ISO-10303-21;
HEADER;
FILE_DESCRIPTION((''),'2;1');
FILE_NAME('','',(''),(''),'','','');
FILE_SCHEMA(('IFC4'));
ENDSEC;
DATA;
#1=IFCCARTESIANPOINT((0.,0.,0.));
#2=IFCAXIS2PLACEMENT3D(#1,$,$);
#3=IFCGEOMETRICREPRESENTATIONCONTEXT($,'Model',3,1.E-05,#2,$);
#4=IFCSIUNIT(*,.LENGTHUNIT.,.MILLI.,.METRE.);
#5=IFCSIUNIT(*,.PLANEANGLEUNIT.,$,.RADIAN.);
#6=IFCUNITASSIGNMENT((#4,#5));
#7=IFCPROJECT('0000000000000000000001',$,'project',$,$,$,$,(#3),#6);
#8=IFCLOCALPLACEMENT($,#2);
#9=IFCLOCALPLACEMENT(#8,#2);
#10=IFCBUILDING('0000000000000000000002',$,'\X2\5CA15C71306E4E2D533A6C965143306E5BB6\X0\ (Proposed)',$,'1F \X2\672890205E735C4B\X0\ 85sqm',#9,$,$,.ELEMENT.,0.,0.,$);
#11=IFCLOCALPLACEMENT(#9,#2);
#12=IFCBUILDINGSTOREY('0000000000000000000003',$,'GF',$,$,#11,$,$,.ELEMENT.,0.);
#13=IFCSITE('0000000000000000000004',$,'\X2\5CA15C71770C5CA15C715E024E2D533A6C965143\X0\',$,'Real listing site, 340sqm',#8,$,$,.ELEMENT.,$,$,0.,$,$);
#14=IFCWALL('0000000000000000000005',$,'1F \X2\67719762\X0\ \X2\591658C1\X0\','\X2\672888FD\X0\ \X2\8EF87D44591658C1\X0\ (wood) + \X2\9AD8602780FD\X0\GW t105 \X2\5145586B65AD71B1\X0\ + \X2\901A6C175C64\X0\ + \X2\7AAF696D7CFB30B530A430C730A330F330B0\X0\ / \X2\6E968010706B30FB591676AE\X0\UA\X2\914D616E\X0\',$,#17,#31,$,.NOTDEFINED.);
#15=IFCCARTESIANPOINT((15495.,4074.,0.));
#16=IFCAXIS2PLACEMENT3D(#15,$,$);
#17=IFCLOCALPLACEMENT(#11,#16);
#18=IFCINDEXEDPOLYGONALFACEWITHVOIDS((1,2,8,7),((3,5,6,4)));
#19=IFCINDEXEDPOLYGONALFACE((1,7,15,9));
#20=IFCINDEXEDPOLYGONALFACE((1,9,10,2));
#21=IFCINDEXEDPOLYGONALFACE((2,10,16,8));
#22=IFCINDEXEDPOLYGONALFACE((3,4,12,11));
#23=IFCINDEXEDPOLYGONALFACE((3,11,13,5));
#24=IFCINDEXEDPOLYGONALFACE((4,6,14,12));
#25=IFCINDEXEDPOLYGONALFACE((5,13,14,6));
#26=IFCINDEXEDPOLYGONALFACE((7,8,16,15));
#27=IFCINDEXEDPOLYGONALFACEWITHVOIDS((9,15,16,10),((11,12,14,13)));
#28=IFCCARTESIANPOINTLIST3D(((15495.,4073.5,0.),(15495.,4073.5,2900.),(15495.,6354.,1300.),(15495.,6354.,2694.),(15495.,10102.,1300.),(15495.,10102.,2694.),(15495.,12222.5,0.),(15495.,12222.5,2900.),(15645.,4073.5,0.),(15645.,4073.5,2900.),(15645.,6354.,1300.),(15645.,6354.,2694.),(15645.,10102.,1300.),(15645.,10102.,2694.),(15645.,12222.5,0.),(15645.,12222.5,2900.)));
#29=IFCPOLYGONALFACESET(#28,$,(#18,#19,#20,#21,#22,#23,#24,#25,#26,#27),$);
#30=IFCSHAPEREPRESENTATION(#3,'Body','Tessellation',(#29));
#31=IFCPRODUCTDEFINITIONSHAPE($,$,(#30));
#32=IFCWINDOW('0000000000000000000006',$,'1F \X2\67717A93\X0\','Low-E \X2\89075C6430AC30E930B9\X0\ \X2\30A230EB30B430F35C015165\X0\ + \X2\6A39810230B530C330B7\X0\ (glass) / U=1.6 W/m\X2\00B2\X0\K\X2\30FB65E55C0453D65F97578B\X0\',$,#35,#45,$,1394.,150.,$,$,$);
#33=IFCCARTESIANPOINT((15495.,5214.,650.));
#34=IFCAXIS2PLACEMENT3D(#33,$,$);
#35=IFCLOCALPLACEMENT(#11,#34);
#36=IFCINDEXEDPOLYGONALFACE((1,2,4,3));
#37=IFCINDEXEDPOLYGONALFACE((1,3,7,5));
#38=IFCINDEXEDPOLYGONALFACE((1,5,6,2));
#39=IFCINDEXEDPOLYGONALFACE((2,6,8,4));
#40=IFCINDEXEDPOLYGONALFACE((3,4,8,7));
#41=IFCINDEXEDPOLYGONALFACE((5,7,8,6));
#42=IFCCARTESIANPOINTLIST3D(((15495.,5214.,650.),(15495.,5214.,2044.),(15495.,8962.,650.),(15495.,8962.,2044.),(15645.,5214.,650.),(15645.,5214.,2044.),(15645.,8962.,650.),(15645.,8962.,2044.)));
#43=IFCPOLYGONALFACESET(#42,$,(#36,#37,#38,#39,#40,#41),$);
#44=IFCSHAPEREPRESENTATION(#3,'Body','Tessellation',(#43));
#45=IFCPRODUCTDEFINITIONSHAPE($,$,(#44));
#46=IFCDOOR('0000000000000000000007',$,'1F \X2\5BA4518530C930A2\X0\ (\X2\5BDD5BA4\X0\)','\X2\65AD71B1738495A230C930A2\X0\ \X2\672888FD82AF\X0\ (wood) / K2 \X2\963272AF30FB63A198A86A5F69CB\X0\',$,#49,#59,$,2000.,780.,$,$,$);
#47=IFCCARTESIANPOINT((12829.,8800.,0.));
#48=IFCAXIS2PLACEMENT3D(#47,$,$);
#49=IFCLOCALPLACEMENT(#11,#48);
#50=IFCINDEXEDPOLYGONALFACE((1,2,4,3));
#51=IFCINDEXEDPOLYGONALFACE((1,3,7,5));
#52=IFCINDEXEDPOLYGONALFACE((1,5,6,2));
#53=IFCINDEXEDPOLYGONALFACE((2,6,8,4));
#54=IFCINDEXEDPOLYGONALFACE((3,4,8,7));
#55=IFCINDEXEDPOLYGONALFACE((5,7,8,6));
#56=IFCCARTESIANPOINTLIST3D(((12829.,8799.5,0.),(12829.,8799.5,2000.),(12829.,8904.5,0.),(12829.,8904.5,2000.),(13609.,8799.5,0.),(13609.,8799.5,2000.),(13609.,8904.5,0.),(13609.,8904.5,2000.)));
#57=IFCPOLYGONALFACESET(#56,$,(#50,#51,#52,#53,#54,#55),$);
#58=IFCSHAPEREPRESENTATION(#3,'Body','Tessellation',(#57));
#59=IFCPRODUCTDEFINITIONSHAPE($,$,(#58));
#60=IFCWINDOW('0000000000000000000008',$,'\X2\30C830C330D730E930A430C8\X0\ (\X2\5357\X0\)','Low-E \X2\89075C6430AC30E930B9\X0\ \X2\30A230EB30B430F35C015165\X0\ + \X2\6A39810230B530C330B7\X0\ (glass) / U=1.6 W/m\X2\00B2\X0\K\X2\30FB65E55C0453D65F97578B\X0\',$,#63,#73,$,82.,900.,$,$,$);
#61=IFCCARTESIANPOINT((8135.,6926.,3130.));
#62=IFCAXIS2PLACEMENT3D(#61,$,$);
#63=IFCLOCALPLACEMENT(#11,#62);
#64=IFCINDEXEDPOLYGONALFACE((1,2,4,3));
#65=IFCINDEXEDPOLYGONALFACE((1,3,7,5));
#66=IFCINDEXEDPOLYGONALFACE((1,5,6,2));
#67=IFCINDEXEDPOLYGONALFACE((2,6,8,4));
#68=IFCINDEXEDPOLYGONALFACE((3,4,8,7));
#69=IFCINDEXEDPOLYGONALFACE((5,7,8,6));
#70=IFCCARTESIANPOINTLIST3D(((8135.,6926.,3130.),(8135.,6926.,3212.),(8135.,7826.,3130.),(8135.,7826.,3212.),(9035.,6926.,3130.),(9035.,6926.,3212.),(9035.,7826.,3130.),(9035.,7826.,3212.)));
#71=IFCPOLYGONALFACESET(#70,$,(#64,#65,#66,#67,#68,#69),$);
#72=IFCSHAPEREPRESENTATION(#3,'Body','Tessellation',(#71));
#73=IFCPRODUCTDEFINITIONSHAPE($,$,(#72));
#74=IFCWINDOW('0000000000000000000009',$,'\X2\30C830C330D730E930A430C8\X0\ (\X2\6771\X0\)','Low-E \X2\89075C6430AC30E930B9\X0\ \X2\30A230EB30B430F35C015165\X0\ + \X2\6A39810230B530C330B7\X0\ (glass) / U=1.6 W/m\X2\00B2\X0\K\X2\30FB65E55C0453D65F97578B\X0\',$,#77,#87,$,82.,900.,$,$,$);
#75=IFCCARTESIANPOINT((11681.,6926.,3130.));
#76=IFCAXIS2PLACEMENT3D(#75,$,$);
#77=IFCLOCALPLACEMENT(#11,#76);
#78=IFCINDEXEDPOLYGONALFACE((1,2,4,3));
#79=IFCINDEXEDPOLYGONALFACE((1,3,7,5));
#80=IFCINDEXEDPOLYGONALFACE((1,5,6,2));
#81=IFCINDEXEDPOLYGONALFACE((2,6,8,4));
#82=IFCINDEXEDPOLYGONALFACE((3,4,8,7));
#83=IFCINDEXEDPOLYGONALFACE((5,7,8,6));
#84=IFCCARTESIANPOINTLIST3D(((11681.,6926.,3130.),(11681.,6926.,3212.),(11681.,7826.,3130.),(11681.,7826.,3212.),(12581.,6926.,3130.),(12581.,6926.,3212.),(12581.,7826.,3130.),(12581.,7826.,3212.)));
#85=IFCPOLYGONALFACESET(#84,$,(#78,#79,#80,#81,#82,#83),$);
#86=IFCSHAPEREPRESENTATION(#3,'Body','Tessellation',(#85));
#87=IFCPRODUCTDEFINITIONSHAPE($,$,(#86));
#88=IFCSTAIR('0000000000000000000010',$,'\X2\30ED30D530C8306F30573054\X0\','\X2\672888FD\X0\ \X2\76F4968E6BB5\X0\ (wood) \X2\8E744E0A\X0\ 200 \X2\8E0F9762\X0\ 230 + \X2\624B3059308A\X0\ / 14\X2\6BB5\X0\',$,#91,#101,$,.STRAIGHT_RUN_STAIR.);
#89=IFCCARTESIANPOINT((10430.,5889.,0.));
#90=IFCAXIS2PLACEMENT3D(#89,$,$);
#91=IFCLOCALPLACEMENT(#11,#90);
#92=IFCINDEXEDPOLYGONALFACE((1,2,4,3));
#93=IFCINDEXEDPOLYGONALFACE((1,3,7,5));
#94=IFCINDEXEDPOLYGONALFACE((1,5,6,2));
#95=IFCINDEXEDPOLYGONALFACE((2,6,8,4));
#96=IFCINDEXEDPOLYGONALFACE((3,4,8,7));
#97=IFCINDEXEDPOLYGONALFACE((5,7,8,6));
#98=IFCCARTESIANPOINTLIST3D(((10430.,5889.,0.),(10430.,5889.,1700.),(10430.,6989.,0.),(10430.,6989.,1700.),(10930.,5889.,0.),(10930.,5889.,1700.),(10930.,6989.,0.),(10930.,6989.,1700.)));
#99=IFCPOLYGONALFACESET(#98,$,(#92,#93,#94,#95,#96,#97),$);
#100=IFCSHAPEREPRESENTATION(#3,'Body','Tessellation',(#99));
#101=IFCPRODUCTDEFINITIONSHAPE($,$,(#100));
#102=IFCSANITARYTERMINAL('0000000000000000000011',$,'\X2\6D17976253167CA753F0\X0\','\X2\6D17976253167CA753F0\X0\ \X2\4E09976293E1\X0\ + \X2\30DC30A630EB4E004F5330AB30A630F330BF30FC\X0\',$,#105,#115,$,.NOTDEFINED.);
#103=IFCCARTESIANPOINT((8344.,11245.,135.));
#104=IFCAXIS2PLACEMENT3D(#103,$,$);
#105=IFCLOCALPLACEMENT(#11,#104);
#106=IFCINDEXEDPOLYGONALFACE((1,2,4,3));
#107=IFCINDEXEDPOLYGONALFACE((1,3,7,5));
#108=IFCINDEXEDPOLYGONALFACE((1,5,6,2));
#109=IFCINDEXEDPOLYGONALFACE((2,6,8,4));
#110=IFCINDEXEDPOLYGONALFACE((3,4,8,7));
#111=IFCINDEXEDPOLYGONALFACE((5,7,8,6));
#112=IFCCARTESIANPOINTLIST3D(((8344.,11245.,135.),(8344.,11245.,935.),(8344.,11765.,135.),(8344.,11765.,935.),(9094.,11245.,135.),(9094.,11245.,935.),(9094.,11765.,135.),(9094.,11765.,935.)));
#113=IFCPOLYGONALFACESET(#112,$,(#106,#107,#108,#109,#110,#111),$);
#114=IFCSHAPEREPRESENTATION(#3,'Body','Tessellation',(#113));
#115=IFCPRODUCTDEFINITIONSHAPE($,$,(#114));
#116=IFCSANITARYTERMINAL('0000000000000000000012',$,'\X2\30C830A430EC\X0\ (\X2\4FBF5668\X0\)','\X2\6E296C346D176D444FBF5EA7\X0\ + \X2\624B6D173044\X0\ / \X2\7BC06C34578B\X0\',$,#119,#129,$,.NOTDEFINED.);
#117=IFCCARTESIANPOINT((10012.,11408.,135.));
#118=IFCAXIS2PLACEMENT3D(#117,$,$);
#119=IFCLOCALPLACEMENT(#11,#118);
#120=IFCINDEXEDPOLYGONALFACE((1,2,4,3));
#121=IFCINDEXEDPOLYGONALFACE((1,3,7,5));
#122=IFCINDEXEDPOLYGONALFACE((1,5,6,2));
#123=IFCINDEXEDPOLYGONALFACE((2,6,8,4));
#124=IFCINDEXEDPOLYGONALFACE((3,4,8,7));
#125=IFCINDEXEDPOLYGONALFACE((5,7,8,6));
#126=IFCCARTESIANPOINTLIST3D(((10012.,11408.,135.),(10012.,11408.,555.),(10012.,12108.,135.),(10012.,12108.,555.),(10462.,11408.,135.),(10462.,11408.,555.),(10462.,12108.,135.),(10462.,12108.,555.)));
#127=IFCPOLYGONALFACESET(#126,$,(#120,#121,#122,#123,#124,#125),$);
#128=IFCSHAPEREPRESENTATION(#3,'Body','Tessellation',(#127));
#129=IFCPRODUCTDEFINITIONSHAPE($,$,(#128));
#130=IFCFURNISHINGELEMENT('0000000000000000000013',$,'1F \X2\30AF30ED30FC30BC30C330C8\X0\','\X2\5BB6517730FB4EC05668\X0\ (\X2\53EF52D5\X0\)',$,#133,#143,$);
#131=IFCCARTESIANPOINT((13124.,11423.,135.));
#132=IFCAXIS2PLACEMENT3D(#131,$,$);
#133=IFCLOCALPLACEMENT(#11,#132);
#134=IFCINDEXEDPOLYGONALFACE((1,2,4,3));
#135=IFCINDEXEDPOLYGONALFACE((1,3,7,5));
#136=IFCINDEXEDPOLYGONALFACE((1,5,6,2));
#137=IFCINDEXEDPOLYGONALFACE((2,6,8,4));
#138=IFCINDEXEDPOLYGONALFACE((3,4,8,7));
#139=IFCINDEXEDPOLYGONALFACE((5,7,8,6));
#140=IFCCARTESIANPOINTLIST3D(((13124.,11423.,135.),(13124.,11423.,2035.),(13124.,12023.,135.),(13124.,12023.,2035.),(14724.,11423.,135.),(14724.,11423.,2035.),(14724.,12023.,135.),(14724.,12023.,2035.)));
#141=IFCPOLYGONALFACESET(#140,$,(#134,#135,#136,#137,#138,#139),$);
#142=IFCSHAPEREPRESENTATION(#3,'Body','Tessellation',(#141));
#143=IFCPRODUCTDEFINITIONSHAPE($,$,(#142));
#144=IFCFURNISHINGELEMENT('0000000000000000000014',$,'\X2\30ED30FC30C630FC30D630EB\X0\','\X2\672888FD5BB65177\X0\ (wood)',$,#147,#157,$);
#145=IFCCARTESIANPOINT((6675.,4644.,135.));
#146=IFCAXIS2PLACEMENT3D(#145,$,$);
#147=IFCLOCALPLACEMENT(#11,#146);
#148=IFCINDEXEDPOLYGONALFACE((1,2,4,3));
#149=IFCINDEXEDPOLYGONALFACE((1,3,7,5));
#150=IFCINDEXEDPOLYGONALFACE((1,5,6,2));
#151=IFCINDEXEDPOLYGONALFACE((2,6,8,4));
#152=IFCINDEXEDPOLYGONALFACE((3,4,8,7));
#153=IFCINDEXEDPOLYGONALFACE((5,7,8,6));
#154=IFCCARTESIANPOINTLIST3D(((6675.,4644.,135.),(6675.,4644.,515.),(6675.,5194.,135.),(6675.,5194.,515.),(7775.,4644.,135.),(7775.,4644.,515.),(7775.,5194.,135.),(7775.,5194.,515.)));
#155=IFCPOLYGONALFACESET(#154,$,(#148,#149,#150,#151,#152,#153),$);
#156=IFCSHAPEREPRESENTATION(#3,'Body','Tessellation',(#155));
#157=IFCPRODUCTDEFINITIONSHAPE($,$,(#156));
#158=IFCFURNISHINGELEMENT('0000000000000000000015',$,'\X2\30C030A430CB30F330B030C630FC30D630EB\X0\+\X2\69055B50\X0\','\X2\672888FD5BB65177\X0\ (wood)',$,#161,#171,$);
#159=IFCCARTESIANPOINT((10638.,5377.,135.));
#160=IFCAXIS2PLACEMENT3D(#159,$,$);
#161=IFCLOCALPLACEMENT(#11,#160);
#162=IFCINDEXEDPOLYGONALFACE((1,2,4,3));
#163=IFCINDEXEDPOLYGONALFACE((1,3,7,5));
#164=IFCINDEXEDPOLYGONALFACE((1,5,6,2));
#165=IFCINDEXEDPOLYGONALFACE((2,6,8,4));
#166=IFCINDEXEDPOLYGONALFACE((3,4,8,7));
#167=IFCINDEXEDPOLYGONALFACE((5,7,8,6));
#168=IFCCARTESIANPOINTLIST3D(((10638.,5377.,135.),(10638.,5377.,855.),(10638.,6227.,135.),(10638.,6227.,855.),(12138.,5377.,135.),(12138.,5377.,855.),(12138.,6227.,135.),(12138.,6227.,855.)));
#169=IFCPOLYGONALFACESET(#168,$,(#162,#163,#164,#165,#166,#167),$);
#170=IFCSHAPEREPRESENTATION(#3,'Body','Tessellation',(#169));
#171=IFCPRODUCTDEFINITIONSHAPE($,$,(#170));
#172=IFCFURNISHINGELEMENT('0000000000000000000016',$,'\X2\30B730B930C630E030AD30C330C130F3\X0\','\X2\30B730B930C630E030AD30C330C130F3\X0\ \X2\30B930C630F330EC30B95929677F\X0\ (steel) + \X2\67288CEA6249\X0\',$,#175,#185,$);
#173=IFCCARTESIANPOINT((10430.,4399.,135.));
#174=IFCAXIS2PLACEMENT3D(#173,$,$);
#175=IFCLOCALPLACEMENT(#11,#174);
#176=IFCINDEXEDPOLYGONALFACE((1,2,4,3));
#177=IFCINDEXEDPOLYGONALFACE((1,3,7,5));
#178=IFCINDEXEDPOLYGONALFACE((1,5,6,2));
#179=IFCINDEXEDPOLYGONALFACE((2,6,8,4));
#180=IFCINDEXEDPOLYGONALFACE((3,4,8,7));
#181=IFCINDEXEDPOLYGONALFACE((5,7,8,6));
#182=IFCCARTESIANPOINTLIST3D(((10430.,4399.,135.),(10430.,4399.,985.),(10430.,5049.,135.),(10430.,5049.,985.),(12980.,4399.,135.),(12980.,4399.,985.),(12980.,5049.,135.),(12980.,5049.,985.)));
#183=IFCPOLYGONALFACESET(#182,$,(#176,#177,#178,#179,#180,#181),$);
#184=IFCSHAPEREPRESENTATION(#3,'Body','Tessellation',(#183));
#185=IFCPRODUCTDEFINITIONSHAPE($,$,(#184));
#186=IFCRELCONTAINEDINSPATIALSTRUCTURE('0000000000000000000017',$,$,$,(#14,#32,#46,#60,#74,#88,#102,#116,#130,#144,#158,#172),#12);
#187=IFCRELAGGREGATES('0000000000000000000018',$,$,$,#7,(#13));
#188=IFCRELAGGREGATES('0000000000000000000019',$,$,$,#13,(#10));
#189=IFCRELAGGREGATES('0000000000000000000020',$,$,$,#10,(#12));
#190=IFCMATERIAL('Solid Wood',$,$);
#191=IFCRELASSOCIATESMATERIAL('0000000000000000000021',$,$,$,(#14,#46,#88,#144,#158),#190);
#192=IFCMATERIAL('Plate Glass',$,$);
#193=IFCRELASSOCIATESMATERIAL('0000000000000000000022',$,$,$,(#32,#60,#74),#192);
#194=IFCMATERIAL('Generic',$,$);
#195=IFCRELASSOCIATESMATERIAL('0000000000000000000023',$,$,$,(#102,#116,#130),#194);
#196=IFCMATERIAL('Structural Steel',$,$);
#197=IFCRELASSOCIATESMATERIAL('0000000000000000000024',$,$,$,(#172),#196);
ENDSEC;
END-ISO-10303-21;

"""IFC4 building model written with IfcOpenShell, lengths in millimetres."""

from ifc_helpers import new_model, si_unit, frame, frame_2d, origin, place, context, project, spatial, rectangle, extrude, material, element, fill, save


model = new_model("IFC4")

# Units and contexts
model_context = context("Model", 3, precision=1e-05, world=origin())
ifc_project = project(units=[si_unit("LENGTHUNIT", "METRE", prefix="MILLI"), si_unit("PLANEANGLEUNIT", "RADIAN")], contexts=[model_context])

# Site, building, storey
site_placement = place(None, origin())
site = spatial("IfcSite", under=ifc_project, at=site_placement, Name="岡山県岡山市中区沖元", ObjectType="Real listing site, 340sqm", CompositionType="ELEMENT", RefElevation=0.0)
building_placement = place(site_placement, origin())
building = spatial("IfcBuilding", under=site, at=building_placement, Name="岡山の中区沖元の家 (Proposed)", ObjectType="1F 木造平屋 85sqm", CompositionType="ELEMENT", ElevationOfRefHeight=0.0, ElevationOfTerrain=0.0)
storey_placement = place(building_placement, origin())
storey = spatial("IfcBuildingStorey", under=building, at=storey_placement, Name="GF", CompositionType="ELEMENT", Elevation=0.0)

# Wall, opening, window
ifc_material_1 = material(Name="Solid Wood")
wall_1_placement = place(storey_placement, frame((15495.0, 4074.0, 0.0)))
wall_1 = element("IfcWall", 1, at=wall_1_placement, inside=storey, material=ifc_material_1, Name="1F 東面 外壁", Description="木製 軸組外壁 (wood) + 高性能GW t105 充填断熱 + 通気層 + 窯業系サイディング / 準耐火・外皮UA配慮", PredefinedType="NOTDEFINED", context=model_context, shape_type="SweptSolid", body=[
    extrude(rectangle(XDim=150.0, YDim=8149.0, at=frame_2d((75.0, 4074.0))), frame((15495.0, 4074.0, 0.0)), (0.0, 0.0, 1.0), 2900.0),
])
opening_placement = place(storey_placement, frame((15495.0, 5214.0, 650.0)))
opening = element("IfcOpeningElement", 2, at=opening_placement, cuts=wall_1, PredefinedType="NOTDEFINED", context=model_context, shape_type="SweptSolid", body=[
    extrude(rectangle(XDim=150.0, YDim=3748.0, at=frame_2d((75.0, 1874.0))), frame((15495.0, 5214.0, 650.0)), (0.0, 0.0, 1.0), 1394.0),
])
ifc_material_2 = material(Name="Plate Glass")
window_1_placement = place(storey_placement, frame((15495.0, 5214.0, 650.0)))
window_1 = element("IfcWindow", 3, at=window_1_placement, inside=storey, material=ifc_material_2, Name="1F 東窓", Description="Low-E 複層ガラス アルゴン封入 + 樹脂サッシ (glass) / U=1.6 W/m²K・日射取得型", OverallHeight=1394.0, OverallWidth=150.0, context=model_context, shape_type="SweptSolid", body=[
    extrude(rectangle(XDim=150.0, YDim=3748.0, at=frame_2d((75.0, 1874.0))), frame((15495.0, 5214.0, 650.0)), (0.0, 0.0, 1.0), 1394.0),
])
fill(opening, window_1)

# Door
door_placement = place(storey_placement, frame((12829.0, 8800.0, 0.0)))
element("IfcDoor", 4, at=door_placement, inside=storey, material=ifc_material_1, Name="1F 室内ドア (寝室)", Description="断熱玄関ドア 木製芯 (wood) / K2 防犯・採風機構", OverallHeight=2000.0, OverallWidth=780.0, context=model_context, shape_type="SweptSolid", body=[
    extrude(rectangle(XDim=780.0, YDim=105.0, at=frame_2d((390.0, 52.0))), frame((12829.0, 8800.0, 0.0)), (0.0, 0.0, 1.0), 2000.0),
])

# Windows
window_2_placement = place(storey_placement, frame((8135.0, 6926.0, 3130.0)))
element("IfcWindow", 5, at=window_2_placement, inside=storey, material=ifc_material_2, Name="トップライト (南)", Description="Low-E 複層ガラス アルゴン封入 + 樹脂サッシ (glass) / U=1.6 W/m²K・日射取得型", OverallHeight=82.0, OverallWidth=900.0, context=model_context, shape_type="SweptSolid", body=[
    extrude(rectangle(XDim=900.0, YDim=900.0, at=frame_2d((450.0, 450.0))), frame((8135.0, 6926.0, 3130.0)), (0.0, 0.0, 1.0), 82.0),
])
window_3_placement = place(storey_placement, frame((11681.0, 6926.0, 3130.0)))
element("IfcWindow", 6, at=window_3_placement, inside=storey, material=ifc_material_2, Name="トップライト (東)", Description="Low-E 複層ガラス アルゴン封入 + 樹脂サッシ (glass) / U=1.6 W/m²K・日射取得型", OverallHeight=82.0, OverallWidth=900.0, context=model_context, shape_type="SweptSolid", body=[
    extrude(rectangle(XDim=900.0, YDim=900.0, at=frame_2d((450.0, 450.0))), frame((11681.0, 6926.0, 3130.0)), (0.0, 0.0, 1.0), 82.0),
])

# Stair
stair_placement = place(storey_placement, frame((10430.0, 5889.0, 0.0)))
element("IfcStair", 7, at=stair_placement, inside=storey, material=ifc_material_1, Name="ロフトはしご", Description="木製 直階段 (wood) 蹴上 200 踏面 230 + 手すり / 14段", PredefinedType="STRAIGHT_RUN_STAIR", context=model_context, shape_type="SweptSolid", body=[
    extrude(rectangle(XDim=500.0, YDim=1100.0, at=frame_2d((250.0, 550.0))), frame((10430.0, 5889.0, 0.0)), (0.0, 0.0, 1.0), 1700.0),
])

# Sanitary terminals
ifc_material_3 = material(Name="Generic")
sanitary_terminal_1_placement = place(storey_placement, frame((8344.0, 11245.0, 135.0)))
element("IfcSanitaryTerminal", 8, at=sanitary_terminal_1_placement, inside=storey, material=ifc_material_3, Name="洗面化粧台", Description="洗面化粧台 三面鏡 + ボウル一体カウンター", PredefinedType="NOTDEFINED", context=model_context, shape_type="SweptSolid", body=[
    extrude(rectangle(XDim=750.0, YDim=520.0, at=frame_2d((375.0, 260.0))), frame((8344.0, 11245.0, 135.0)), (0.0, 0.0, 1.0), 800.0),
])
sanitary_terminal_2_placement = place(storey_placement, frame((10012.0, 11408.0, 135.0)))
element("IfcSanitaryTerminal", 9, at=sanitary_terminal_2_placement, inside=storey, material=ifc_material_3, Name="トイレ (便器)", Description="温水洗浄便座 + 手洗い / 節水型", PredefinedType="NOTDEFINED", context=model_context, shape_type="SweptSolid", body=[
    extrude(rectangle(XDim=450.0, YDim=700.0, at=frame_2d((225.0, 350.0))), frame((10012.0, 11408.0, 135.0)), (0.0, 0.0, 1.0), 420.0),
])

# Furnishing elements
furnishing_1_placement = place(storey_placement, frame((13124.0, 11423.0, 135.0)))
element("IfcFurnishingElement", 10, at=furnishing_1_placement, inside=storey, material=ifc_material_3, Name="1F クローゼット", Description="家具・什器 (可動)", context=model_context, shape_type="SweptSolid", body=[
    extrude(rectangle(XDim=1600.0, YDim=600.0, at=frame_2d((800.0, 300.0))), frame((13124.0, 11423.0, 135.0)), (0.0, 0.0, 1.0), 1900.0),
])
furnishing_2_placement = place(storey_placement, frame((6675.0, 4644.0, 135.0)))
element("IfcFurnishingElement", 11, at=furnishing_2_placement, inside=storey, material=ifc_material_1, Name="ローテーブル", Description="木製家具 (wood)", context=model_context, shape_type="SweptSolid", body=[
    extrude(rectangle(XDim=1100.0, YDim=550.0, at=frame_2d((550.0, 275.0))), frame((6675.0, 4644.0, 135.0)), (0.0, 0.0, 1.0), 380.0),
])
furnishing_3_placement = place(storey_placement, frame((10638.0, 5377.0, 135.0)))
element("IfcFurnishingElement", 12, at=furnishing_3_placement, inside=storey, material=ifc_material_1, Name="ダイニングテーブル+椅子", Description="木製家具 (wood)", context=model_context, shape_type="SweptSolid", body=[
    extrude(rectangle(XDim=1500.0, YDim=850.0, at=frame_2d((750.0, 425.0))), frame((10638.0, 5377.0, 135.0)), (0.0, 0.0, 1.0), 720.0),
])
ifc_material_4 = material(Name="Structural Steel")
furnishing_4_placement = place(storey_placement, frame((10430.0, 4399.0, 135.0)))
element("IfcFurnishingElement", 13, at=furnishing_4_placement, inside=storey, material=ifc_material_4, Name="システムキッチン", Description="システムキッチン ステンレス天板 (steel) + 木質扉", context=model_context, shape_type="SweptSolid", body=[
    extrude(rectangle(XDim=2550.0, YDim=650.0, at=frame_2d((1275.0, 325.0))), frame((10430.0, 4399.0, 135.0)), (0.0, 0.0, 1.0), 850.0),
])

save(model, "model.ifc")
